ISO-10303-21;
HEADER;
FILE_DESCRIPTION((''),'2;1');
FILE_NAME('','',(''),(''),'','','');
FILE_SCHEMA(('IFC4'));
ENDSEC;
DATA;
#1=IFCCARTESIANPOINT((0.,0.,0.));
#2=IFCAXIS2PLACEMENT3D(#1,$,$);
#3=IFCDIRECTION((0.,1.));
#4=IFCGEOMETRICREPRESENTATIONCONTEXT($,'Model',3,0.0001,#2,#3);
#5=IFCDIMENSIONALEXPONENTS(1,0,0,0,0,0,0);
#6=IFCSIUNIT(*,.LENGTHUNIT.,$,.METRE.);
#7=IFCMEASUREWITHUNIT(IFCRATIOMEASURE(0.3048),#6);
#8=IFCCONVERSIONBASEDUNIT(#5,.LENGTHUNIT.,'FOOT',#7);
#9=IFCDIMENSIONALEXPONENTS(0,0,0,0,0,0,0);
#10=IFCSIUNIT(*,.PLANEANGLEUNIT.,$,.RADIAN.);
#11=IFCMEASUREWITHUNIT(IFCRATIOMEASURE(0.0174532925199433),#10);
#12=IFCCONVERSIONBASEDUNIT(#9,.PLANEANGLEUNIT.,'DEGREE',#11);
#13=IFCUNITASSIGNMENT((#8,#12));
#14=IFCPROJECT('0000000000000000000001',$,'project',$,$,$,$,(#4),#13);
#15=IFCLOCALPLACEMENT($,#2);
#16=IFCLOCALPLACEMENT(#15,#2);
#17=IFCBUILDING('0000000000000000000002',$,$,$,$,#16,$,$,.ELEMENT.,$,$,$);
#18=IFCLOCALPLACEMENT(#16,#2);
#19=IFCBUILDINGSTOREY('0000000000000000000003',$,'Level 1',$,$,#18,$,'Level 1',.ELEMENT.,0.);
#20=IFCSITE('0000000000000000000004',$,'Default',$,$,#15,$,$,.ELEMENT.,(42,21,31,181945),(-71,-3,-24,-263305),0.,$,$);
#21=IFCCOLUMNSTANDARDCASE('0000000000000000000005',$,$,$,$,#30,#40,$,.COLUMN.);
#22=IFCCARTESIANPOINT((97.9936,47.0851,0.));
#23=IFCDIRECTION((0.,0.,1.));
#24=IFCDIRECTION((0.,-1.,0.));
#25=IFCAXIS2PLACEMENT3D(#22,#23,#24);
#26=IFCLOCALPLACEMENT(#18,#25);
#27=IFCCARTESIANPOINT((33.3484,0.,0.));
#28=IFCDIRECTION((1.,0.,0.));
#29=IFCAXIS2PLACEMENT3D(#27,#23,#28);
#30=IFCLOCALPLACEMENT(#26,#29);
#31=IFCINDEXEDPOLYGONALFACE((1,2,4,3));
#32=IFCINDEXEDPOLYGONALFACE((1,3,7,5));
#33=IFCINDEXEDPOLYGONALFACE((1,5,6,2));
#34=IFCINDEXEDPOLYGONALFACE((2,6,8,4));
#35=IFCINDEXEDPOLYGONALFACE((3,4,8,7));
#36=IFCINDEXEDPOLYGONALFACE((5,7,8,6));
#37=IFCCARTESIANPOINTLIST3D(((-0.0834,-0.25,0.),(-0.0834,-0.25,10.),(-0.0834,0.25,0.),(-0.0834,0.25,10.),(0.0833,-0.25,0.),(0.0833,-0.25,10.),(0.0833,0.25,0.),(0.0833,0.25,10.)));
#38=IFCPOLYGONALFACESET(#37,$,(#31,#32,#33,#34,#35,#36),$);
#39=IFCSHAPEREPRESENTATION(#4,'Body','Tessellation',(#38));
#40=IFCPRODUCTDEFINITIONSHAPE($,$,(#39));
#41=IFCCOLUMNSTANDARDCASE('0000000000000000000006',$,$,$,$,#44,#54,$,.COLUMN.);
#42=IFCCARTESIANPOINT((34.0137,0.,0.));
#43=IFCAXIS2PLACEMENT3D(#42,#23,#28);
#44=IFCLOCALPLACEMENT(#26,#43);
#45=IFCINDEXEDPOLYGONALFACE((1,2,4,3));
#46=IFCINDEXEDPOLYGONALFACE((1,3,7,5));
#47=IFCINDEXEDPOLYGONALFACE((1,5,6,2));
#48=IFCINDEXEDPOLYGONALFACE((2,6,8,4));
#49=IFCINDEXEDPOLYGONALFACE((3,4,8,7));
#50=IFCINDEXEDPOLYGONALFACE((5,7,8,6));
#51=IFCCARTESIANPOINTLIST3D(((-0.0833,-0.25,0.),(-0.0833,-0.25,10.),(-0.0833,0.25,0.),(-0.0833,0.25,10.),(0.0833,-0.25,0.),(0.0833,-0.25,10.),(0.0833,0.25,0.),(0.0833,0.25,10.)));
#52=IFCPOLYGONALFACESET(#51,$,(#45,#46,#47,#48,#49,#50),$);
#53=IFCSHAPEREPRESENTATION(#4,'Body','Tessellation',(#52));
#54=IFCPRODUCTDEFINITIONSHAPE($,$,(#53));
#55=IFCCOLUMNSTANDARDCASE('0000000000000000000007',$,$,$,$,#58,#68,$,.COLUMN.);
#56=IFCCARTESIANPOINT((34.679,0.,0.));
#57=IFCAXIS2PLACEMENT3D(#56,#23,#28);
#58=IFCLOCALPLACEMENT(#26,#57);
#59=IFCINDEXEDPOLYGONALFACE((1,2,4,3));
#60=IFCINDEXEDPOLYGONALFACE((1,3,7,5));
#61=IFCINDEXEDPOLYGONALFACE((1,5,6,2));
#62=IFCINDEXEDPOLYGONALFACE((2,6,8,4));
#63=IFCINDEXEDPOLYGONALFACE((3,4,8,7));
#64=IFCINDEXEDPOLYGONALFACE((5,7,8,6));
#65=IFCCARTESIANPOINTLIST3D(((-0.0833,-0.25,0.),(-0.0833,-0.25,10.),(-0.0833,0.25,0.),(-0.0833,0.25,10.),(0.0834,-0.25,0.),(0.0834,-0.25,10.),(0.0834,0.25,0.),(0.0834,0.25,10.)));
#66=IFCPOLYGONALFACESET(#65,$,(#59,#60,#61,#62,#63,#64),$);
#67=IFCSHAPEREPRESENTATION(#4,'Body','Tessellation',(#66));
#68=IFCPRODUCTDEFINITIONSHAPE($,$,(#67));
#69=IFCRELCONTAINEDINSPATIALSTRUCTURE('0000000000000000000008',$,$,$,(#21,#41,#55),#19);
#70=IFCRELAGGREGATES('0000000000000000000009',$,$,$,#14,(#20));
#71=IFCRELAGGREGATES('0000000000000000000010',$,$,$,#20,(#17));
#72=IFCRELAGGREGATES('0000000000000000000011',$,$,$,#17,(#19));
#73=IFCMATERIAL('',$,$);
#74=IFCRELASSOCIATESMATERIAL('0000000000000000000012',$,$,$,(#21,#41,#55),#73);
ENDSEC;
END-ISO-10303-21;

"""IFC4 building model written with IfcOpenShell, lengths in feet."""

from ifc_helpers import new_model, entity, si_unit, converted_unit, direction, frame, origin, place, context, project, spatial, rectangle, extrude, material, element, save


model = new_model("IFC4")

# Units and contexts
model_context = context("Model", 3, precision=0.0001, world=origin(), true_north=direction((0.0, 1.0)))
ifc_project = project(units=[converted_unit("LENGTHUNIT", "FOOT", entity("IfcRatioMeasure", 0.3048), si_unit("LENGTHUNIT", "METRE"), dimensions=[1, 0, 0, 0, 0, 0, 0]), converted_unit("PLANEANGLEUNIT", "DEGREE", entity("IfcRatioMeasure", 0.0174532925199433), si_unit("PLANEANGLEUNIT", "RADIAN"), dimensions=[0, 0, 0, 0, 0, 0, 0])], contexts=[model_context])

# Site, building, storey
site_placement = place(None, origin())
site = spatial("IfcSite", under=ifc_project, at=site_placement, Name="Default", CompositionType="ELEMENT", RefLatitude=(42, 21, 31, 181945), RefLongitude=(-71, -3, -24, -263305), RefElevation=0.0)
building_placement = place(site_placement, origin())
building = spatial("IfcBuilding", under=site, at=building_placement, CompositionType="ELEMENT")
storey_placement = place(building_placement, origin())
storey = spatial("IfcBuildingStorey", under=building, at=storey_placement, Name="Level 1", LongName="Level 1", CompositionType="ELEMENT", Elevation=0.0)

# Columns
ifc_material = material(Name="")
placement = place(storey_placement, frame((97.9936, 47.0851, 0.0), z_axis=(0.0, 0.0, 1.0), x_axis=(0.0, -1.0, 0.0)))
for number, where, z_axis, x_axis in (
    (1, (33.3484, 0.0, 0.0), (0.0, 0.0, 1.0), (1.0, 0.0, 0.0)),
    (2, (34.0137, 0.0, 0.0), (0.0, 0.0, 1.0), (1.0, 0.0, 0.0)),
    (3, (34.679, 0.0, 0.0), (0.0, 0.0, 1.0), (1.0, 0.0, 0.0)),
):
    element("IfcColumnStandardCase", number, at=place(placement, frame(where, z_axis=z_axis, x_axis=x_axis)), inside=storey, material=ifc_material, PredefinedType="COLUMN", context=model_context, shape_type="SweptSolid", body=[
        extrude(rectangle(XDim=0.1667, YDim=0.5), origin(), (0.0, 0.0, 1.0), 10.0),
    ])

save(model, "model.ifc")
